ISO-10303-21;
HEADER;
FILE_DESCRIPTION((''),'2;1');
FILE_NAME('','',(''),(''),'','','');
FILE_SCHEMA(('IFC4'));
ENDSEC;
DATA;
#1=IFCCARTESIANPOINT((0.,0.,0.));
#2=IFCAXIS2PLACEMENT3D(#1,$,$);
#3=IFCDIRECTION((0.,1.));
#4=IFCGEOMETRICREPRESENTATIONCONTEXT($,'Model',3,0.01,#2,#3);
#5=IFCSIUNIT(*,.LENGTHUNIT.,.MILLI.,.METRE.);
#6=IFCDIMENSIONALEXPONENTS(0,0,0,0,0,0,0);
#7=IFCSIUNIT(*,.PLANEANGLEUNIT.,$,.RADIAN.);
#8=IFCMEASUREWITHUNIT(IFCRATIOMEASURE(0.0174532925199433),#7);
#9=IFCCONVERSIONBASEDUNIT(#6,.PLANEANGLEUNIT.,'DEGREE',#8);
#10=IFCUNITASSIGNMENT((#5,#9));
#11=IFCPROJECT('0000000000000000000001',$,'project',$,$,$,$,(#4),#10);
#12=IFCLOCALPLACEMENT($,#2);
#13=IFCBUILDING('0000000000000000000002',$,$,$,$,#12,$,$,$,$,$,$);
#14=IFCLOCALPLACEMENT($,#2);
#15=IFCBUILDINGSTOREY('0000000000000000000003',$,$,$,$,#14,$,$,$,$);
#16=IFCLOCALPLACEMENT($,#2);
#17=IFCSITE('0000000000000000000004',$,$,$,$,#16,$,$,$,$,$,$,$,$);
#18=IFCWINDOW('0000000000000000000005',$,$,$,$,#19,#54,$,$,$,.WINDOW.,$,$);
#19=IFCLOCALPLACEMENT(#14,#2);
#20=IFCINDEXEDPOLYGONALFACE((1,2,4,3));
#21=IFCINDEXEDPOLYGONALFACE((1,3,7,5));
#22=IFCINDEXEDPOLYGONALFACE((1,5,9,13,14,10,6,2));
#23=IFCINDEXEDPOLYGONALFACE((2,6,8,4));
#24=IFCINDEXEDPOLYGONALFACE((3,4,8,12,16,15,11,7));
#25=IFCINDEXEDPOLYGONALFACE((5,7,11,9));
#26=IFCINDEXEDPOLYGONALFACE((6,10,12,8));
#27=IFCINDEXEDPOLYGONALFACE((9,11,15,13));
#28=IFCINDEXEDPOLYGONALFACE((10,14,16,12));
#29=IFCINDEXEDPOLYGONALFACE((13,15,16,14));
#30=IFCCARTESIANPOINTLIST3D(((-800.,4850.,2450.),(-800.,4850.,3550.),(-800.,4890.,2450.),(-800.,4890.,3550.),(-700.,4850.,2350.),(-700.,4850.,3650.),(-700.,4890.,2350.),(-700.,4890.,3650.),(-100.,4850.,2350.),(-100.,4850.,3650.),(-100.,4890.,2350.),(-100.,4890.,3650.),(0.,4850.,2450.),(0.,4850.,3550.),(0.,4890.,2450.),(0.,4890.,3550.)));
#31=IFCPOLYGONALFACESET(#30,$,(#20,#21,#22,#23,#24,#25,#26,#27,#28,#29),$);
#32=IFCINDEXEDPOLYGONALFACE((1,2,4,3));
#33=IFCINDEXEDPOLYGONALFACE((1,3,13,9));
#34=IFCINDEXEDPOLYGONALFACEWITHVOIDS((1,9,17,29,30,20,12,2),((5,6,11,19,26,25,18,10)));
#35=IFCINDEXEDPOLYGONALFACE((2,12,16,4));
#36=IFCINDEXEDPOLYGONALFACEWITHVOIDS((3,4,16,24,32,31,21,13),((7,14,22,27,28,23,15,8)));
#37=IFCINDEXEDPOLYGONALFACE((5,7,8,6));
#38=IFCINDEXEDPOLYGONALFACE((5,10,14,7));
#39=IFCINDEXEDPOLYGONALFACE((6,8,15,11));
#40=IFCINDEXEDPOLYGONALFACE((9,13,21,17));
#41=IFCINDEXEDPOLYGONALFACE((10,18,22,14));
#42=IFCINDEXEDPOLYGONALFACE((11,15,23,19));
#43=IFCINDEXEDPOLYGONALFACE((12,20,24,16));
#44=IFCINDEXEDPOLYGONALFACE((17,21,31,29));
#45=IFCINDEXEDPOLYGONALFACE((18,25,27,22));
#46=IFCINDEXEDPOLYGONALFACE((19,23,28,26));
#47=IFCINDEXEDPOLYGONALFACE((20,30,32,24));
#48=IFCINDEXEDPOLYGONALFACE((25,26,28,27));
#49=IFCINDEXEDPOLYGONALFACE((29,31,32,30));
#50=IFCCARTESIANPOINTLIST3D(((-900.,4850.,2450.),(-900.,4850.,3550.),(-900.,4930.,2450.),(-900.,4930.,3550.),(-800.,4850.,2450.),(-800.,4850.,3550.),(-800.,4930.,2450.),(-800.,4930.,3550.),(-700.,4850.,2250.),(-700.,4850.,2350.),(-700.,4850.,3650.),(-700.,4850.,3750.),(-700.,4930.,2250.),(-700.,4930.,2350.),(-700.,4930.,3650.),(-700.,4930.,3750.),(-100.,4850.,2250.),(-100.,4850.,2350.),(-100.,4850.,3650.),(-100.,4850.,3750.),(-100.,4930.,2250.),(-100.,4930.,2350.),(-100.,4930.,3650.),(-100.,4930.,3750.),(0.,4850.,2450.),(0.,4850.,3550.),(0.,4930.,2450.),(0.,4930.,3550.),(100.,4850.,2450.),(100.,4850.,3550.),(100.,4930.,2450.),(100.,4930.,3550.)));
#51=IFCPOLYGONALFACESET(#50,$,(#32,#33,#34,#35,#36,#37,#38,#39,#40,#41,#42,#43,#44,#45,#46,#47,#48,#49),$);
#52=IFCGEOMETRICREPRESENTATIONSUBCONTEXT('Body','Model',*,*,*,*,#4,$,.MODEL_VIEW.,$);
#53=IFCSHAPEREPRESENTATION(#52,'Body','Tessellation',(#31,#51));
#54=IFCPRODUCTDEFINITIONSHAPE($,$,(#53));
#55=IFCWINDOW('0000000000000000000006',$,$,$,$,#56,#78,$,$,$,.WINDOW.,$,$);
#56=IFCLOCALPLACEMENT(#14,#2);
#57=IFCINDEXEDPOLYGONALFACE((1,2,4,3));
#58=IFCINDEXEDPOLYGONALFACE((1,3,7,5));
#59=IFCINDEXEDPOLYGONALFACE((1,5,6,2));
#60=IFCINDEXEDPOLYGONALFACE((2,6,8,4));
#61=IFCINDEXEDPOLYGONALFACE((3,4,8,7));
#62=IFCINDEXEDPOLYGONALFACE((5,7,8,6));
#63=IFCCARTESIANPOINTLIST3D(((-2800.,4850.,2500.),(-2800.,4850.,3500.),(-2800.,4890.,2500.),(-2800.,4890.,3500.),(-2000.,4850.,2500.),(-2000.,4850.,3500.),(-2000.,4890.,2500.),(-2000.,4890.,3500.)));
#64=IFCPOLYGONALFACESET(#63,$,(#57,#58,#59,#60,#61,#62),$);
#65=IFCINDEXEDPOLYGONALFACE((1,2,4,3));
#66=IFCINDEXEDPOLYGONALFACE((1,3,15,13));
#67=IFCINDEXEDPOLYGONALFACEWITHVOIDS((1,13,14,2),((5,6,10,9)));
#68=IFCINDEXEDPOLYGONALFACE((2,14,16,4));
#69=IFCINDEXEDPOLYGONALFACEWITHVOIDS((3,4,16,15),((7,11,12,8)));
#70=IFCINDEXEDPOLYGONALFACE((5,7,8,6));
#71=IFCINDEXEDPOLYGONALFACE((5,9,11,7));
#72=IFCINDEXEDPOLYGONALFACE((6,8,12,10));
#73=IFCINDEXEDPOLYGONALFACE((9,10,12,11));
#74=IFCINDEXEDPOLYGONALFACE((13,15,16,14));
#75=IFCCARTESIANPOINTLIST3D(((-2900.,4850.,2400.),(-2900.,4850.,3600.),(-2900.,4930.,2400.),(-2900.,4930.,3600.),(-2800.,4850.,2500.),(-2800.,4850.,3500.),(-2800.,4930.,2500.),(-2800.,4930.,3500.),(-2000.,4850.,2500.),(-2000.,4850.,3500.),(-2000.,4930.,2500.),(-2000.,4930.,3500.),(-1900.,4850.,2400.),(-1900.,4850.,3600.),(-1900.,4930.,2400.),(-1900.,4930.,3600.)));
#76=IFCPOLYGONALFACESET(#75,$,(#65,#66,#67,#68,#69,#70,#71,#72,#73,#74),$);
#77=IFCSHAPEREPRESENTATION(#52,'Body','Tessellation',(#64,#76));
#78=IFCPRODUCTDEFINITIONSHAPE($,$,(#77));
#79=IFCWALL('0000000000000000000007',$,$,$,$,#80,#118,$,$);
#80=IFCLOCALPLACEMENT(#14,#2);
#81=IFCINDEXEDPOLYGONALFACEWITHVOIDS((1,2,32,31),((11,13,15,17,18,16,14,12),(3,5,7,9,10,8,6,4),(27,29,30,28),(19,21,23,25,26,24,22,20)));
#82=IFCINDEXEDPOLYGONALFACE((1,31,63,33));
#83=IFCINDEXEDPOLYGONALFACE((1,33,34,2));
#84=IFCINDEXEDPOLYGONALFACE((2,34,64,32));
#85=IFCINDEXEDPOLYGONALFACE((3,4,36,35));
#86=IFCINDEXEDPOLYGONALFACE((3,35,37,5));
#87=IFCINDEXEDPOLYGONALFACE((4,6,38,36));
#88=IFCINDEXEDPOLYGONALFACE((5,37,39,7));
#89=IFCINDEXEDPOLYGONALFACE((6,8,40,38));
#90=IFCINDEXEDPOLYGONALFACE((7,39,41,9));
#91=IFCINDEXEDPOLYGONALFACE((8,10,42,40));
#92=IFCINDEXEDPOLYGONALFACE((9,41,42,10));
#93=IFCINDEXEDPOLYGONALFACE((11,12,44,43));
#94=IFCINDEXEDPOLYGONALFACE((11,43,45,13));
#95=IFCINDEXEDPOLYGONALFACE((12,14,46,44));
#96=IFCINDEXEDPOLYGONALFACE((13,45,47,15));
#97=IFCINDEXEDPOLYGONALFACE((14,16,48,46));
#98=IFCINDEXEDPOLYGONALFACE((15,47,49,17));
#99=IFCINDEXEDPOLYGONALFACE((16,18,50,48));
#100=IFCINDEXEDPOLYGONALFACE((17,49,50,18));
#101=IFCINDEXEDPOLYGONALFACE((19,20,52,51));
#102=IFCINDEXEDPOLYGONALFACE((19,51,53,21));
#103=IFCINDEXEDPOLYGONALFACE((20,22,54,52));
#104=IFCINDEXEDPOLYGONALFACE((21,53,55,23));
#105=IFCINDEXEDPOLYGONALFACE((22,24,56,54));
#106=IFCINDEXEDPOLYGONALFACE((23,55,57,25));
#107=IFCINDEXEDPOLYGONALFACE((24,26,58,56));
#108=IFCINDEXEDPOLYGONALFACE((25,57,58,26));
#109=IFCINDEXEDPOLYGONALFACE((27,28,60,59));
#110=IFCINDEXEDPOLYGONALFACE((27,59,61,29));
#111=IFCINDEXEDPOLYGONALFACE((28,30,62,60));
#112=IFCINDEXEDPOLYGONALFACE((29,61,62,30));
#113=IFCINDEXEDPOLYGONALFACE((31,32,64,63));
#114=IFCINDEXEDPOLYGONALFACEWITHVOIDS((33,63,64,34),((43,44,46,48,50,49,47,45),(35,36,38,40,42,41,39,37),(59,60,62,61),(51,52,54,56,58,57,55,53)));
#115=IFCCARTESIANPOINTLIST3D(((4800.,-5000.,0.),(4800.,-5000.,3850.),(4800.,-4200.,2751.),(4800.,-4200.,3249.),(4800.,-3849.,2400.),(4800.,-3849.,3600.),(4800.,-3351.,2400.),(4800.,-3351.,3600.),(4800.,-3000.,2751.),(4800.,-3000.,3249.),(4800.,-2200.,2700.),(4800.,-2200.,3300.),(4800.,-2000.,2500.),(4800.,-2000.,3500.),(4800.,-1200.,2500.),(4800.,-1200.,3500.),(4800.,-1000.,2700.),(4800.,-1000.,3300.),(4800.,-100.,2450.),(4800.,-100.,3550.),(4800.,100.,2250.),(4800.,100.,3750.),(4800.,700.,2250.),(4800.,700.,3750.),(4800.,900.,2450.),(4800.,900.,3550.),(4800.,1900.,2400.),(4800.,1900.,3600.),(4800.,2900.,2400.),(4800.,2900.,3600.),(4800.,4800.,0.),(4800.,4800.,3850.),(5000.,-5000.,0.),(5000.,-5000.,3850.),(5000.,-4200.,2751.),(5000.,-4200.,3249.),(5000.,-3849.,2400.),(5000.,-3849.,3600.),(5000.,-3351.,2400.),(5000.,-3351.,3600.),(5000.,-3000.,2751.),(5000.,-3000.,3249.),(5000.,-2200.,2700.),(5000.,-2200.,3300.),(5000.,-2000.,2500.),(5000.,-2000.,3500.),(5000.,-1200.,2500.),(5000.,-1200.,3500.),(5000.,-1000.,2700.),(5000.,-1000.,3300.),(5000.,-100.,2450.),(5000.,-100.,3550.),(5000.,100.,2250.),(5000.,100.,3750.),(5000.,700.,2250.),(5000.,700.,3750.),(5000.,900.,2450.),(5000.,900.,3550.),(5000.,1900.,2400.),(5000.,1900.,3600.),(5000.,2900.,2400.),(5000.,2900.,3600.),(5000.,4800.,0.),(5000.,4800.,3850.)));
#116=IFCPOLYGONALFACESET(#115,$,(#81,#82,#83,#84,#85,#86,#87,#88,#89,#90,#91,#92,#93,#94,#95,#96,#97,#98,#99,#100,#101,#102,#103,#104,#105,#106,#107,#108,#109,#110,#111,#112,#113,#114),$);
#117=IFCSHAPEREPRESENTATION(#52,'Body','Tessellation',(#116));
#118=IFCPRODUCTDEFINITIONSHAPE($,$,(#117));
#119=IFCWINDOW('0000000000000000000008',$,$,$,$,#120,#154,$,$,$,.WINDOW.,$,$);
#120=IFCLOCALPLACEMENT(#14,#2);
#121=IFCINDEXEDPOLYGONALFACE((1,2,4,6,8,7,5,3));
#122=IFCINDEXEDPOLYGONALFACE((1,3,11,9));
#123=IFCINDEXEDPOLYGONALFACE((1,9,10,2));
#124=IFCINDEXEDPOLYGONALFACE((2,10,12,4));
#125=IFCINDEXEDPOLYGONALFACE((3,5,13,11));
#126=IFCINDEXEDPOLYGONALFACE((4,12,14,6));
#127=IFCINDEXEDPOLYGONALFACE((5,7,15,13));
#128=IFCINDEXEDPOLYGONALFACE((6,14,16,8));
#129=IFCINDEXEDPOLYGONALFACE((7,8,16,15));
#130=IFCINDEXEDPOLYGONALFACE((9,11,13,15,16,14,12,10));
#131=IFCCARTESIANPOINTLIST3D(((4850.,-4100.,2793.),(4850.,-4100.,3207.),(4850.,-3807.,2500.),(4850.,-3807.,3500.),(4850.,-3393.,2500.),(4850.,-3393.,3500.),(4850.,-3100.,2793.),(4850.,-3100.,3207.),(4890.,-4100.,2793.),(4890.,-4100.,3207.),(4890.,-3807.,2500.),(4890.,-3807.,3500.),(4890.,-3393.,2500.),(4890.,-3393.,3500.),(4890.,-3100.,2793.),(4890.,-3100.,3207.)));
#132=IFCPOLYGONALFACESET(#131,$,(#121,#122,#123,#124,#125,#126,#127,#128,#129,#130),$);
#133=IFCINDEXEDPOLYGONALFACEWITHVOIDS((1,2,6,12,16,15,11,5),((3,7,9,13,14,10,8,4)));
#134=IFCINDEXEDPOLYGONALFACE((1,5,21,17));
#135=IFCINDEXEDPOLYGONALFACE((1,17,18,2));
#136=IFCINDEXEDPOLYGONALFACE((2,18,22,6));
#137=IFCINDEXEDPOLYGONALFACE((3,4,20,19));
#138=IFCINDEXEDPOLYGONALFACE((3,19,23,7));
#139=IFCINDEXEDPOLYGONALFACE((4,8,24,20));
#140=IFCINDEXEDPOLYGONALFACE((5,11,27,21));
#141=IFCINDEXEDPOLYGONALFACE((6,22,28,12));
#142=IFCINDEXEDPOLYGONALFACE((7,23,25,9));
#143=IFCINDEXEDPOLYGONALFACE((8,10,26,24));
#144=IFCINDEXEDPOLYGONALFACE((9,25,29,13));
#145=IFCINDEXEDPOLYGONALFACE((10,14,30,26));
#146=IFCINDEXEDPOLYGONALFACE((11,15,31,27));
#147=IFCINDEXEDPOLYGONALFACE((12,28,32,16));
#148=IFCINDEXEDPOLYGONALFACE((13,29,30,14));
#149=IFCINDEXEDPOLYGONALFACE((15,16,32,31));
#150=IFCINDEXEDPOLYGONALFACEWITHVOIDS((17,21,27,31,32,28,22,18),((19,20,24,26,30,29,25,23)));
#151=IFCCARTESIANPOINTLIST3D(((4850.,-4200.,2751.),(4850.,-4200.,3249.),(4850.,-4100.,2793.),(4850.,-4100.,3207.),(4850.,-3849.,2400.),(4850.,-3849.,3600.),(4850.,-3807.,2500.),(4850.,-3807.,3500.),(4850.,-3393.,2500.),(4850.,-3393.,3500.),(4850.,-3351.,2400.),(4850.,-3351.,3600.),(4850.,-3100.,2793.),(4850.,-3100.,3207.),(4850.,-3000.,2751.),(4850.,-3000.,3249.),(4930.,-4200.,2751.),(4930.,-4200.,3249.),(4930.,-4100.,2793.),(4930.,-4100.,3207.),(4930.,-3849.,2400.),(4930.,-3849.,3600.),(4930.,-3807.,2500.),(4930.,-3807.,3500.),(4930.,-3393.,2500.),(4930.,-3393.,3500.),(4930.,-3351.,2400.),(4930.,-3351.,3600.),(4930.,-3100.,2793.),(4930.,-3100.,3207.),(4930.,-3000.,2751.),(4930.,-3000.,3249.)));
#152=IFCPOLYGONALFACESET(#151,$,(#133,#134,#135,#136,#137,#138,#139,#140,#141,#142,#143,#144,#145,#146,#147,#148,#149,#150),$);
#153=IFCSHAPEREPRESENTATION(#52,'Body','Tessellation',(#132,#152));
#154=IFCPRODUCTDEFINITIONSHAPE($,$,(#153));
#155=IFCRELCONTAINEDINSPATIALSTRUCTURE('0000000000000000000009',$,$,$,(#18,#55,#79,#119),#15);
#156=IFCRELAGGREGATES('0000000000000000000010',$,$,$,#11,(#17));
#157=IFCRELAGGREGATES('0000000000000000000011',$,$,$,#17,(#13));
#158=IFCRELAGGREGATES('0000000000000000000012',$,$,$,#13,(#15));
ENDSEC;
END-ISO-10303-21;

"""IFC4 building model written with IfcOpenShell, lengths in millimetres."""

from ifc_helpers import new_model, entity, si_unit, converted_unit, direction, frame, origin, origin_2d, place, context, subcontext, project, spatial, polyline, rectangle, outline, extrude, element, save


model = new_model("IFC4")

# Units and contexts
model_context = context("Model", 3, precision=0.01, world=origin(), true_north=direction((0.0, 1.0)))
body_context = subcontext(model_context, "Body", "Model", "MODEL_VIEW")
ifc_project = project(units=[si_unit("LENGTHUNIT", "METRE", prefix="MILLI"), converted_unit("PLANEANGLEUNIT", "DEGREE", entity("IfcRatioMeasure", 0.0174532925199433), si_unit("PLANEANGLEUNIT", "RADIAN"), dimensions=[0, 0, 0, 0, 0, 0, 0])], contexts=[model_context])

# Site, building, storey
site_placement = place(None, origin())
site = spatial("IfcSite", under=ifc_project, at=site_placement)
building_placement = place(None, origin())
building = spatial("IfcBuilding", under=site, at=building_placement)
storey_placement = place(None, origin())
storey = spatial("IfcBuildingStorey", under=building, at=storey_placement)

# Shared definitions
wall_1_placement = place(storey_placement, frame((100.0, 4900.0, 0.0), z_axis=(0.0, 0.0, 1.0), x_axis=(-1.0, 0.0, 0.0)))
window_1_placement = place(wall_1_placement, frame((500.0, 50.0, 3000.0)))
window_2_placement = place(wall_1_placement, frame((2500.0, 50.0, 3000.0)))

# Windows
cartesian_point_1 = entity("IfcCartesianPoint", [-500.0, -207.0])
shared_polyline_1 = entity("IfcPolyline", [cartesian_point_1, entity("IfcCartesianPoint", [-500.0, 207.0]), entity("IfcCartesianPoint", [-207.0, 500.0]), entity("IfcCartesianPoint", [207.0, 500.0]), entity("IfcCartesianPoint", [500.0, 207.0]), entity("IfcCartesianPoint", [500.0, -207.0]), entity("IfcCartesianPoint", [207.0, -500.0]), entity("IfcCartesianPoint", [-207.0, -500.0]), cartesian_point_1])
cartesian_point_2 = entity("IfcCartesianPoint", [-400.0, -550.0])
shared_polyline_2 = entity("IfcPolyline", [cartesian_point_2, entity("IfcCartesianPoint", [-400.0, 550.0]), entity("IfcCartesianPoint", [-300.0, 650.0]), entity("IfcCartesianPoint", [300.0, 650.0]), entity("IfcCartesianPoint", [400.0, 550.0]), entity("IfcCartesianPoint", [400.0, -550.0]), entity("IfcCartesianPoint", [300.0, -650.0]), entity("IfcCartesianPoint", [-300.0, -650.0]), cartesian_point_2])
cartesian_point_3 = entity("IfcCartesianPoint", [-500.0, -550.0])
element("IfcWindow", 1, at=window_1_placement, inside=storey, PredefinedType="WINDOW", context=body_context, shape_type="SweptSolid", body=[
    entity("IfcExtrudedAreaSolid", entity("IfcArbitraryClosedProfileDef", "AREA", None, shared_polyline_2), entity("IfcAxis2Placement3D", entity("IfcCartesianPoint", [0.0, 0.0, 0.0]), entity("IfcDirection", [0.0, -1.0, 0.0]), entity("IfcDirection", [1.0, 0.0, 0.0])), entity("IfcDirection", [0.0, 0.0, 1.0]), 40.0),
    entity("IfcExtrudedAreaSolid", entity("IfcArbitraryProfileDefWithVoids", "AREA", None, entity("IfcPolyline", [cartesian_point_3, entity("IfcCartesianPoint", [-500.0, 550.0]), entity("IfcCartesianPoint", [-300.0, 750.0]), entity("IfcCartesianPoint", [300.0, 750.0]), entity("IfcCartesianPoint", [500.0, 550.0]), entity("IfcCartesianPoint", [500.0, -550.0]), entity("IfcCartesianPoint", [300.0, -750.0]), entity("IfcCartesianPoint", [-300.0, -750.0]), cartesian_point_3]), [shared_polyline_2]), entity("IfcAxis2Placement3D", entity("IfcCartesianPoint", [0.0, 0.0, 0.0]), entity("IfcDirection", [0.0, -1.0, 0.0]), entity("IfcDirection", [1.0, 0.0, 0.0])), entity("IfcDirection", [0.0, 0.0, 1.0]), 80.0),
])
cartesian_point_4 = entity("IfcCartesianPoint", [-400.0, -500.0])
shared_polyline_3 = entity("IfcPolyline", [cartesian_point_4, entity("IfcCartesianPoint", [-400.0, 500.0]), entity("IfcCartesianPoint", [-400.0, 500.0]), entity("IfcCartesianPoint", [400.0, 500.0]), entity("IfcCartesianPoint", [400.0, 500.0]), entity("IfcCartesianPoint", [400.0, -500.0]), entity("IfcCartesianPoint", [400.0, -500.0]), entity("IfcCartesianPoint", [-400.0, -500.0]), cartesian_point_4])
cartesian_point_5 = entity("IfcCartesianPoint", [-500.0, -600.0])
element("IfcWindow", 2, at=window_2_placement, inside=storey, PredefinedType="WINDOW", context=body_context, shape_type="SweptSolid", body=[
    entity("IfcExtrudedAreaSolid", entity("IfcArbitraryClosedProfileDef", "AREA", None, shared_polyline_3), entity("IfcAxis2Placement3D", entity("IfcCartesianPoint", [0.0, 0.0, 0.0]), entity("IfcDirection", [0.0, -1.0, 0.0]), entity("IfcDirection", [1.0, 0.0, 0.0])), entity("IfcDirection", [0.0, 0.0, 1.0]), 40.0),
    entity("IfcExtrudedAreaSolid", entity("IfcArbitraryProfileDefWithVoids", "AREA", None, entity("IfcPolyline", [cartesian_point_5, entity("IfcCartesianPoint", [-500.0, 600.0]), entity("IfcCartesianPoint", [-500.0, 600.0]), entity("IfcCartesianPoint", [500.0, 600.0]), entity("IfcCartesianPoint", [500.0, 600.0]), entity("IfcCartesianPoint", [500.0, -600.0]), entity("IfcCartesianPoint", [500.0, -600.0]), entity("IfcCartesianPoint", [-500.0, -600.0]), cartesian_point_5]), [shared_polyline_3]), entity("IfcAxis2Placement3D", entity("IfcCartesianPoint", [0.0, 0.0, 0.0]), entity("IfcDirection", [0.0, -1.0, 0.0]), entity("IfcDirection", [1.0, 0.0, 0.0])), entity("IfcDirection", [0.0, 0.0, 1.0]), 80.0),
])

# Wall, openings
wall_2_placement = place(storey_placement, frame((4900.0, -100.0, 0.0), z_axis=(0.0, 0.0, 1.0), x_axis=(0.0, 1.0, 0.0)))
wall_2 = element("IfcWall", 3, at=wall_2_placement, inside=storey, context=body_context, shape_type="SweptSolid", body=[
    extrude(rectangle(XDim=9800.0, YDim=200.0, at=origin_2d()), origin(), (0.0, 0.0, 1.0), 3850.0),
])
window_3_placement = place(wall_2_placement, frame((-3500.0, 50.0, 3000.0)))
opening_1_placement = place(window_3_placement, frame((0.0, 50.0, 0.0)))
element("IfcOpeningElement", 4, at=opening_1_placement, cuts=wall_2, context=body_context, shape_type="SweptSolid", body=[
    extrude(outline(polyline([(-600.0, -249.0), (-600.0, 249.0), (-249.0, 600.0), (249.0, 600.0), (600.0, 249.0), (600.0, -249.0), (249.0, -600.0), (-249.0, -600.0), (-600.0, -249.0)])), frame((0.0, 0.0, 0.0), z_axis=(0.0, -1.0, 0.0), x_axis=(1.0, 0.0, 0.0)), (0.0, 0.0, 1.0), 200.0),
])
window_4_placement = place(wall_2_placement, frame((-1500.0, 50.0, 3000.0)))
opening_2_placement = place(window_4_placement, frame((0.0, 50.0, 0.0)))
element("IfcOpeningElement", 5, at=opening_2_placement, cuts=wall_2, context=body_context, shape_type="SweptSolid", body=[
    extrude(outline(polyline([(-600.0, -300.0), (-600.0, 300.0), (-400.0, 500.0), (400.0, 500.0), (600.0, 300.0), (600.0, -300.0), (400.0, -500.0), (-400.0, -500.0), (-600.0, -300.0)])), frame((0.0, 0.0, 0.0), z_axis=(0.0, -1.0, 0.0), x_axis=(1.0, 0.0, 0.0)), (0.0, 0.0, 1.0), 200.0),
])
window_5_placement = place(wall_2_placement, frame((500.0, 50.0, 3000.0)))
opening_3_placement = place(window_5_placement, frame((0.0, 50.0, 0.0)))
element("IfcOpeningElement", 6, at=opening_3_placement, cuts=wall_2, context=body_context, shape_type="SweptSolid", body=[
    extrude(outline(polyline([(-500.0, -550.0), (-500.0, 550.0), (-300.0, 750.0), (300.0, 750.0), (500.0, 550.0), (500.0, -550.0), (300.0, -750.0), (-300.0, -750.0), (-500.0, -550.0)])), frame((0.0, 0.0, 0.0), z_axis=(0.0, -1.0, 0.0), x_axis=(1.0, 0.0, 0.0)), (0.0, 0.0, 1.0), 200.0),
])
window_6_placement = place(wall_2_placement, frame((2500.0, 50.0, 3000.0)))
opening_4_placement = place(window_6_placement, frame((0.0, 50.0, 0.0)))
element("IfcOpeningElement", 7, at=opening_4_placement, cuts=wall_2, context=body_context, shape_type="SweptSolid", body=[
    extrude(outline(polyline([(-500.0, -600.0), (-500.0, 600.0), (-500.0, 600.0), (500.0, 600.0), (500.0, 600.0), (500.0, -600.0), (500.0, -600.0), (-500.0, -600.0), (-500.0, -600.0)])), frame((0.0, 0.0, 0.0), z_axis=(0.0, -1.0, 0.0), x_axis=(1.0, 0.0, 0.0)), (0.0, 0.0, 1.0), 200.0),
])

# Window
cartesian_point_6 = entity("IfcCartesianPoint", [-600.0, -249.0])
element("IfcWindow", 8, at=window_3_placement, inside=storey, PredefinedType="WINDOW", context=body_context, shape_type="SweptSolid", body=[
    entity("IfcExtrudedAreaSolid", entity("IfcArbitraryClosedProfileDef", "AREA", None, shared_polyline_1), entity("IfcAxis2Placement3D", entity("IfcCartesianPoint", [0.0, 0.0, 0.0]), entity("IfcDirection", [0.0, -1.0, 0.0]), entity("IfcDirection", [1.0, 0.0, 0.0])), entity("IfcDirection", [0.0, 0.0, 1.0]), 40.0),
    entity("IfcExtrudedAreaSolid", entity("IfcArbitraryProfileDefWithVoids", "AREA", None, entity("IfcPolyline", [cartesian_point_6, entity("IfcCartesianPoint", [-600.0, 249.0]), entity("IfcCartesianPoint", [-249.0, 600.0]), entity("IfcCartesianPoint", [249.0, 600.0]), entity("IfcCartesianPoint", [600.0, 249.0]), entity("IfcCartesianPoint", [600.0, -249.0]), entity("IfcCartesianPoint", [249.0, -600.0]), entity("IfcCartesianPoint", [-249.0, -600.0]), cartesian_point_6]), [shared_polyline_1]), entity("IfcAxis2Placement3D", entity("IfcCartesianPoint", [0.0, 0.0, 0.0]), entity("IfcDirection", [0.0, -1.0, 0.0]), entity("IfcDirection", [1.0, 0.0, 0.0])), entity("IfcDirection", [0.0, 0.0, 1.0]), 80.0),
])

save(model, "model.ifc")
